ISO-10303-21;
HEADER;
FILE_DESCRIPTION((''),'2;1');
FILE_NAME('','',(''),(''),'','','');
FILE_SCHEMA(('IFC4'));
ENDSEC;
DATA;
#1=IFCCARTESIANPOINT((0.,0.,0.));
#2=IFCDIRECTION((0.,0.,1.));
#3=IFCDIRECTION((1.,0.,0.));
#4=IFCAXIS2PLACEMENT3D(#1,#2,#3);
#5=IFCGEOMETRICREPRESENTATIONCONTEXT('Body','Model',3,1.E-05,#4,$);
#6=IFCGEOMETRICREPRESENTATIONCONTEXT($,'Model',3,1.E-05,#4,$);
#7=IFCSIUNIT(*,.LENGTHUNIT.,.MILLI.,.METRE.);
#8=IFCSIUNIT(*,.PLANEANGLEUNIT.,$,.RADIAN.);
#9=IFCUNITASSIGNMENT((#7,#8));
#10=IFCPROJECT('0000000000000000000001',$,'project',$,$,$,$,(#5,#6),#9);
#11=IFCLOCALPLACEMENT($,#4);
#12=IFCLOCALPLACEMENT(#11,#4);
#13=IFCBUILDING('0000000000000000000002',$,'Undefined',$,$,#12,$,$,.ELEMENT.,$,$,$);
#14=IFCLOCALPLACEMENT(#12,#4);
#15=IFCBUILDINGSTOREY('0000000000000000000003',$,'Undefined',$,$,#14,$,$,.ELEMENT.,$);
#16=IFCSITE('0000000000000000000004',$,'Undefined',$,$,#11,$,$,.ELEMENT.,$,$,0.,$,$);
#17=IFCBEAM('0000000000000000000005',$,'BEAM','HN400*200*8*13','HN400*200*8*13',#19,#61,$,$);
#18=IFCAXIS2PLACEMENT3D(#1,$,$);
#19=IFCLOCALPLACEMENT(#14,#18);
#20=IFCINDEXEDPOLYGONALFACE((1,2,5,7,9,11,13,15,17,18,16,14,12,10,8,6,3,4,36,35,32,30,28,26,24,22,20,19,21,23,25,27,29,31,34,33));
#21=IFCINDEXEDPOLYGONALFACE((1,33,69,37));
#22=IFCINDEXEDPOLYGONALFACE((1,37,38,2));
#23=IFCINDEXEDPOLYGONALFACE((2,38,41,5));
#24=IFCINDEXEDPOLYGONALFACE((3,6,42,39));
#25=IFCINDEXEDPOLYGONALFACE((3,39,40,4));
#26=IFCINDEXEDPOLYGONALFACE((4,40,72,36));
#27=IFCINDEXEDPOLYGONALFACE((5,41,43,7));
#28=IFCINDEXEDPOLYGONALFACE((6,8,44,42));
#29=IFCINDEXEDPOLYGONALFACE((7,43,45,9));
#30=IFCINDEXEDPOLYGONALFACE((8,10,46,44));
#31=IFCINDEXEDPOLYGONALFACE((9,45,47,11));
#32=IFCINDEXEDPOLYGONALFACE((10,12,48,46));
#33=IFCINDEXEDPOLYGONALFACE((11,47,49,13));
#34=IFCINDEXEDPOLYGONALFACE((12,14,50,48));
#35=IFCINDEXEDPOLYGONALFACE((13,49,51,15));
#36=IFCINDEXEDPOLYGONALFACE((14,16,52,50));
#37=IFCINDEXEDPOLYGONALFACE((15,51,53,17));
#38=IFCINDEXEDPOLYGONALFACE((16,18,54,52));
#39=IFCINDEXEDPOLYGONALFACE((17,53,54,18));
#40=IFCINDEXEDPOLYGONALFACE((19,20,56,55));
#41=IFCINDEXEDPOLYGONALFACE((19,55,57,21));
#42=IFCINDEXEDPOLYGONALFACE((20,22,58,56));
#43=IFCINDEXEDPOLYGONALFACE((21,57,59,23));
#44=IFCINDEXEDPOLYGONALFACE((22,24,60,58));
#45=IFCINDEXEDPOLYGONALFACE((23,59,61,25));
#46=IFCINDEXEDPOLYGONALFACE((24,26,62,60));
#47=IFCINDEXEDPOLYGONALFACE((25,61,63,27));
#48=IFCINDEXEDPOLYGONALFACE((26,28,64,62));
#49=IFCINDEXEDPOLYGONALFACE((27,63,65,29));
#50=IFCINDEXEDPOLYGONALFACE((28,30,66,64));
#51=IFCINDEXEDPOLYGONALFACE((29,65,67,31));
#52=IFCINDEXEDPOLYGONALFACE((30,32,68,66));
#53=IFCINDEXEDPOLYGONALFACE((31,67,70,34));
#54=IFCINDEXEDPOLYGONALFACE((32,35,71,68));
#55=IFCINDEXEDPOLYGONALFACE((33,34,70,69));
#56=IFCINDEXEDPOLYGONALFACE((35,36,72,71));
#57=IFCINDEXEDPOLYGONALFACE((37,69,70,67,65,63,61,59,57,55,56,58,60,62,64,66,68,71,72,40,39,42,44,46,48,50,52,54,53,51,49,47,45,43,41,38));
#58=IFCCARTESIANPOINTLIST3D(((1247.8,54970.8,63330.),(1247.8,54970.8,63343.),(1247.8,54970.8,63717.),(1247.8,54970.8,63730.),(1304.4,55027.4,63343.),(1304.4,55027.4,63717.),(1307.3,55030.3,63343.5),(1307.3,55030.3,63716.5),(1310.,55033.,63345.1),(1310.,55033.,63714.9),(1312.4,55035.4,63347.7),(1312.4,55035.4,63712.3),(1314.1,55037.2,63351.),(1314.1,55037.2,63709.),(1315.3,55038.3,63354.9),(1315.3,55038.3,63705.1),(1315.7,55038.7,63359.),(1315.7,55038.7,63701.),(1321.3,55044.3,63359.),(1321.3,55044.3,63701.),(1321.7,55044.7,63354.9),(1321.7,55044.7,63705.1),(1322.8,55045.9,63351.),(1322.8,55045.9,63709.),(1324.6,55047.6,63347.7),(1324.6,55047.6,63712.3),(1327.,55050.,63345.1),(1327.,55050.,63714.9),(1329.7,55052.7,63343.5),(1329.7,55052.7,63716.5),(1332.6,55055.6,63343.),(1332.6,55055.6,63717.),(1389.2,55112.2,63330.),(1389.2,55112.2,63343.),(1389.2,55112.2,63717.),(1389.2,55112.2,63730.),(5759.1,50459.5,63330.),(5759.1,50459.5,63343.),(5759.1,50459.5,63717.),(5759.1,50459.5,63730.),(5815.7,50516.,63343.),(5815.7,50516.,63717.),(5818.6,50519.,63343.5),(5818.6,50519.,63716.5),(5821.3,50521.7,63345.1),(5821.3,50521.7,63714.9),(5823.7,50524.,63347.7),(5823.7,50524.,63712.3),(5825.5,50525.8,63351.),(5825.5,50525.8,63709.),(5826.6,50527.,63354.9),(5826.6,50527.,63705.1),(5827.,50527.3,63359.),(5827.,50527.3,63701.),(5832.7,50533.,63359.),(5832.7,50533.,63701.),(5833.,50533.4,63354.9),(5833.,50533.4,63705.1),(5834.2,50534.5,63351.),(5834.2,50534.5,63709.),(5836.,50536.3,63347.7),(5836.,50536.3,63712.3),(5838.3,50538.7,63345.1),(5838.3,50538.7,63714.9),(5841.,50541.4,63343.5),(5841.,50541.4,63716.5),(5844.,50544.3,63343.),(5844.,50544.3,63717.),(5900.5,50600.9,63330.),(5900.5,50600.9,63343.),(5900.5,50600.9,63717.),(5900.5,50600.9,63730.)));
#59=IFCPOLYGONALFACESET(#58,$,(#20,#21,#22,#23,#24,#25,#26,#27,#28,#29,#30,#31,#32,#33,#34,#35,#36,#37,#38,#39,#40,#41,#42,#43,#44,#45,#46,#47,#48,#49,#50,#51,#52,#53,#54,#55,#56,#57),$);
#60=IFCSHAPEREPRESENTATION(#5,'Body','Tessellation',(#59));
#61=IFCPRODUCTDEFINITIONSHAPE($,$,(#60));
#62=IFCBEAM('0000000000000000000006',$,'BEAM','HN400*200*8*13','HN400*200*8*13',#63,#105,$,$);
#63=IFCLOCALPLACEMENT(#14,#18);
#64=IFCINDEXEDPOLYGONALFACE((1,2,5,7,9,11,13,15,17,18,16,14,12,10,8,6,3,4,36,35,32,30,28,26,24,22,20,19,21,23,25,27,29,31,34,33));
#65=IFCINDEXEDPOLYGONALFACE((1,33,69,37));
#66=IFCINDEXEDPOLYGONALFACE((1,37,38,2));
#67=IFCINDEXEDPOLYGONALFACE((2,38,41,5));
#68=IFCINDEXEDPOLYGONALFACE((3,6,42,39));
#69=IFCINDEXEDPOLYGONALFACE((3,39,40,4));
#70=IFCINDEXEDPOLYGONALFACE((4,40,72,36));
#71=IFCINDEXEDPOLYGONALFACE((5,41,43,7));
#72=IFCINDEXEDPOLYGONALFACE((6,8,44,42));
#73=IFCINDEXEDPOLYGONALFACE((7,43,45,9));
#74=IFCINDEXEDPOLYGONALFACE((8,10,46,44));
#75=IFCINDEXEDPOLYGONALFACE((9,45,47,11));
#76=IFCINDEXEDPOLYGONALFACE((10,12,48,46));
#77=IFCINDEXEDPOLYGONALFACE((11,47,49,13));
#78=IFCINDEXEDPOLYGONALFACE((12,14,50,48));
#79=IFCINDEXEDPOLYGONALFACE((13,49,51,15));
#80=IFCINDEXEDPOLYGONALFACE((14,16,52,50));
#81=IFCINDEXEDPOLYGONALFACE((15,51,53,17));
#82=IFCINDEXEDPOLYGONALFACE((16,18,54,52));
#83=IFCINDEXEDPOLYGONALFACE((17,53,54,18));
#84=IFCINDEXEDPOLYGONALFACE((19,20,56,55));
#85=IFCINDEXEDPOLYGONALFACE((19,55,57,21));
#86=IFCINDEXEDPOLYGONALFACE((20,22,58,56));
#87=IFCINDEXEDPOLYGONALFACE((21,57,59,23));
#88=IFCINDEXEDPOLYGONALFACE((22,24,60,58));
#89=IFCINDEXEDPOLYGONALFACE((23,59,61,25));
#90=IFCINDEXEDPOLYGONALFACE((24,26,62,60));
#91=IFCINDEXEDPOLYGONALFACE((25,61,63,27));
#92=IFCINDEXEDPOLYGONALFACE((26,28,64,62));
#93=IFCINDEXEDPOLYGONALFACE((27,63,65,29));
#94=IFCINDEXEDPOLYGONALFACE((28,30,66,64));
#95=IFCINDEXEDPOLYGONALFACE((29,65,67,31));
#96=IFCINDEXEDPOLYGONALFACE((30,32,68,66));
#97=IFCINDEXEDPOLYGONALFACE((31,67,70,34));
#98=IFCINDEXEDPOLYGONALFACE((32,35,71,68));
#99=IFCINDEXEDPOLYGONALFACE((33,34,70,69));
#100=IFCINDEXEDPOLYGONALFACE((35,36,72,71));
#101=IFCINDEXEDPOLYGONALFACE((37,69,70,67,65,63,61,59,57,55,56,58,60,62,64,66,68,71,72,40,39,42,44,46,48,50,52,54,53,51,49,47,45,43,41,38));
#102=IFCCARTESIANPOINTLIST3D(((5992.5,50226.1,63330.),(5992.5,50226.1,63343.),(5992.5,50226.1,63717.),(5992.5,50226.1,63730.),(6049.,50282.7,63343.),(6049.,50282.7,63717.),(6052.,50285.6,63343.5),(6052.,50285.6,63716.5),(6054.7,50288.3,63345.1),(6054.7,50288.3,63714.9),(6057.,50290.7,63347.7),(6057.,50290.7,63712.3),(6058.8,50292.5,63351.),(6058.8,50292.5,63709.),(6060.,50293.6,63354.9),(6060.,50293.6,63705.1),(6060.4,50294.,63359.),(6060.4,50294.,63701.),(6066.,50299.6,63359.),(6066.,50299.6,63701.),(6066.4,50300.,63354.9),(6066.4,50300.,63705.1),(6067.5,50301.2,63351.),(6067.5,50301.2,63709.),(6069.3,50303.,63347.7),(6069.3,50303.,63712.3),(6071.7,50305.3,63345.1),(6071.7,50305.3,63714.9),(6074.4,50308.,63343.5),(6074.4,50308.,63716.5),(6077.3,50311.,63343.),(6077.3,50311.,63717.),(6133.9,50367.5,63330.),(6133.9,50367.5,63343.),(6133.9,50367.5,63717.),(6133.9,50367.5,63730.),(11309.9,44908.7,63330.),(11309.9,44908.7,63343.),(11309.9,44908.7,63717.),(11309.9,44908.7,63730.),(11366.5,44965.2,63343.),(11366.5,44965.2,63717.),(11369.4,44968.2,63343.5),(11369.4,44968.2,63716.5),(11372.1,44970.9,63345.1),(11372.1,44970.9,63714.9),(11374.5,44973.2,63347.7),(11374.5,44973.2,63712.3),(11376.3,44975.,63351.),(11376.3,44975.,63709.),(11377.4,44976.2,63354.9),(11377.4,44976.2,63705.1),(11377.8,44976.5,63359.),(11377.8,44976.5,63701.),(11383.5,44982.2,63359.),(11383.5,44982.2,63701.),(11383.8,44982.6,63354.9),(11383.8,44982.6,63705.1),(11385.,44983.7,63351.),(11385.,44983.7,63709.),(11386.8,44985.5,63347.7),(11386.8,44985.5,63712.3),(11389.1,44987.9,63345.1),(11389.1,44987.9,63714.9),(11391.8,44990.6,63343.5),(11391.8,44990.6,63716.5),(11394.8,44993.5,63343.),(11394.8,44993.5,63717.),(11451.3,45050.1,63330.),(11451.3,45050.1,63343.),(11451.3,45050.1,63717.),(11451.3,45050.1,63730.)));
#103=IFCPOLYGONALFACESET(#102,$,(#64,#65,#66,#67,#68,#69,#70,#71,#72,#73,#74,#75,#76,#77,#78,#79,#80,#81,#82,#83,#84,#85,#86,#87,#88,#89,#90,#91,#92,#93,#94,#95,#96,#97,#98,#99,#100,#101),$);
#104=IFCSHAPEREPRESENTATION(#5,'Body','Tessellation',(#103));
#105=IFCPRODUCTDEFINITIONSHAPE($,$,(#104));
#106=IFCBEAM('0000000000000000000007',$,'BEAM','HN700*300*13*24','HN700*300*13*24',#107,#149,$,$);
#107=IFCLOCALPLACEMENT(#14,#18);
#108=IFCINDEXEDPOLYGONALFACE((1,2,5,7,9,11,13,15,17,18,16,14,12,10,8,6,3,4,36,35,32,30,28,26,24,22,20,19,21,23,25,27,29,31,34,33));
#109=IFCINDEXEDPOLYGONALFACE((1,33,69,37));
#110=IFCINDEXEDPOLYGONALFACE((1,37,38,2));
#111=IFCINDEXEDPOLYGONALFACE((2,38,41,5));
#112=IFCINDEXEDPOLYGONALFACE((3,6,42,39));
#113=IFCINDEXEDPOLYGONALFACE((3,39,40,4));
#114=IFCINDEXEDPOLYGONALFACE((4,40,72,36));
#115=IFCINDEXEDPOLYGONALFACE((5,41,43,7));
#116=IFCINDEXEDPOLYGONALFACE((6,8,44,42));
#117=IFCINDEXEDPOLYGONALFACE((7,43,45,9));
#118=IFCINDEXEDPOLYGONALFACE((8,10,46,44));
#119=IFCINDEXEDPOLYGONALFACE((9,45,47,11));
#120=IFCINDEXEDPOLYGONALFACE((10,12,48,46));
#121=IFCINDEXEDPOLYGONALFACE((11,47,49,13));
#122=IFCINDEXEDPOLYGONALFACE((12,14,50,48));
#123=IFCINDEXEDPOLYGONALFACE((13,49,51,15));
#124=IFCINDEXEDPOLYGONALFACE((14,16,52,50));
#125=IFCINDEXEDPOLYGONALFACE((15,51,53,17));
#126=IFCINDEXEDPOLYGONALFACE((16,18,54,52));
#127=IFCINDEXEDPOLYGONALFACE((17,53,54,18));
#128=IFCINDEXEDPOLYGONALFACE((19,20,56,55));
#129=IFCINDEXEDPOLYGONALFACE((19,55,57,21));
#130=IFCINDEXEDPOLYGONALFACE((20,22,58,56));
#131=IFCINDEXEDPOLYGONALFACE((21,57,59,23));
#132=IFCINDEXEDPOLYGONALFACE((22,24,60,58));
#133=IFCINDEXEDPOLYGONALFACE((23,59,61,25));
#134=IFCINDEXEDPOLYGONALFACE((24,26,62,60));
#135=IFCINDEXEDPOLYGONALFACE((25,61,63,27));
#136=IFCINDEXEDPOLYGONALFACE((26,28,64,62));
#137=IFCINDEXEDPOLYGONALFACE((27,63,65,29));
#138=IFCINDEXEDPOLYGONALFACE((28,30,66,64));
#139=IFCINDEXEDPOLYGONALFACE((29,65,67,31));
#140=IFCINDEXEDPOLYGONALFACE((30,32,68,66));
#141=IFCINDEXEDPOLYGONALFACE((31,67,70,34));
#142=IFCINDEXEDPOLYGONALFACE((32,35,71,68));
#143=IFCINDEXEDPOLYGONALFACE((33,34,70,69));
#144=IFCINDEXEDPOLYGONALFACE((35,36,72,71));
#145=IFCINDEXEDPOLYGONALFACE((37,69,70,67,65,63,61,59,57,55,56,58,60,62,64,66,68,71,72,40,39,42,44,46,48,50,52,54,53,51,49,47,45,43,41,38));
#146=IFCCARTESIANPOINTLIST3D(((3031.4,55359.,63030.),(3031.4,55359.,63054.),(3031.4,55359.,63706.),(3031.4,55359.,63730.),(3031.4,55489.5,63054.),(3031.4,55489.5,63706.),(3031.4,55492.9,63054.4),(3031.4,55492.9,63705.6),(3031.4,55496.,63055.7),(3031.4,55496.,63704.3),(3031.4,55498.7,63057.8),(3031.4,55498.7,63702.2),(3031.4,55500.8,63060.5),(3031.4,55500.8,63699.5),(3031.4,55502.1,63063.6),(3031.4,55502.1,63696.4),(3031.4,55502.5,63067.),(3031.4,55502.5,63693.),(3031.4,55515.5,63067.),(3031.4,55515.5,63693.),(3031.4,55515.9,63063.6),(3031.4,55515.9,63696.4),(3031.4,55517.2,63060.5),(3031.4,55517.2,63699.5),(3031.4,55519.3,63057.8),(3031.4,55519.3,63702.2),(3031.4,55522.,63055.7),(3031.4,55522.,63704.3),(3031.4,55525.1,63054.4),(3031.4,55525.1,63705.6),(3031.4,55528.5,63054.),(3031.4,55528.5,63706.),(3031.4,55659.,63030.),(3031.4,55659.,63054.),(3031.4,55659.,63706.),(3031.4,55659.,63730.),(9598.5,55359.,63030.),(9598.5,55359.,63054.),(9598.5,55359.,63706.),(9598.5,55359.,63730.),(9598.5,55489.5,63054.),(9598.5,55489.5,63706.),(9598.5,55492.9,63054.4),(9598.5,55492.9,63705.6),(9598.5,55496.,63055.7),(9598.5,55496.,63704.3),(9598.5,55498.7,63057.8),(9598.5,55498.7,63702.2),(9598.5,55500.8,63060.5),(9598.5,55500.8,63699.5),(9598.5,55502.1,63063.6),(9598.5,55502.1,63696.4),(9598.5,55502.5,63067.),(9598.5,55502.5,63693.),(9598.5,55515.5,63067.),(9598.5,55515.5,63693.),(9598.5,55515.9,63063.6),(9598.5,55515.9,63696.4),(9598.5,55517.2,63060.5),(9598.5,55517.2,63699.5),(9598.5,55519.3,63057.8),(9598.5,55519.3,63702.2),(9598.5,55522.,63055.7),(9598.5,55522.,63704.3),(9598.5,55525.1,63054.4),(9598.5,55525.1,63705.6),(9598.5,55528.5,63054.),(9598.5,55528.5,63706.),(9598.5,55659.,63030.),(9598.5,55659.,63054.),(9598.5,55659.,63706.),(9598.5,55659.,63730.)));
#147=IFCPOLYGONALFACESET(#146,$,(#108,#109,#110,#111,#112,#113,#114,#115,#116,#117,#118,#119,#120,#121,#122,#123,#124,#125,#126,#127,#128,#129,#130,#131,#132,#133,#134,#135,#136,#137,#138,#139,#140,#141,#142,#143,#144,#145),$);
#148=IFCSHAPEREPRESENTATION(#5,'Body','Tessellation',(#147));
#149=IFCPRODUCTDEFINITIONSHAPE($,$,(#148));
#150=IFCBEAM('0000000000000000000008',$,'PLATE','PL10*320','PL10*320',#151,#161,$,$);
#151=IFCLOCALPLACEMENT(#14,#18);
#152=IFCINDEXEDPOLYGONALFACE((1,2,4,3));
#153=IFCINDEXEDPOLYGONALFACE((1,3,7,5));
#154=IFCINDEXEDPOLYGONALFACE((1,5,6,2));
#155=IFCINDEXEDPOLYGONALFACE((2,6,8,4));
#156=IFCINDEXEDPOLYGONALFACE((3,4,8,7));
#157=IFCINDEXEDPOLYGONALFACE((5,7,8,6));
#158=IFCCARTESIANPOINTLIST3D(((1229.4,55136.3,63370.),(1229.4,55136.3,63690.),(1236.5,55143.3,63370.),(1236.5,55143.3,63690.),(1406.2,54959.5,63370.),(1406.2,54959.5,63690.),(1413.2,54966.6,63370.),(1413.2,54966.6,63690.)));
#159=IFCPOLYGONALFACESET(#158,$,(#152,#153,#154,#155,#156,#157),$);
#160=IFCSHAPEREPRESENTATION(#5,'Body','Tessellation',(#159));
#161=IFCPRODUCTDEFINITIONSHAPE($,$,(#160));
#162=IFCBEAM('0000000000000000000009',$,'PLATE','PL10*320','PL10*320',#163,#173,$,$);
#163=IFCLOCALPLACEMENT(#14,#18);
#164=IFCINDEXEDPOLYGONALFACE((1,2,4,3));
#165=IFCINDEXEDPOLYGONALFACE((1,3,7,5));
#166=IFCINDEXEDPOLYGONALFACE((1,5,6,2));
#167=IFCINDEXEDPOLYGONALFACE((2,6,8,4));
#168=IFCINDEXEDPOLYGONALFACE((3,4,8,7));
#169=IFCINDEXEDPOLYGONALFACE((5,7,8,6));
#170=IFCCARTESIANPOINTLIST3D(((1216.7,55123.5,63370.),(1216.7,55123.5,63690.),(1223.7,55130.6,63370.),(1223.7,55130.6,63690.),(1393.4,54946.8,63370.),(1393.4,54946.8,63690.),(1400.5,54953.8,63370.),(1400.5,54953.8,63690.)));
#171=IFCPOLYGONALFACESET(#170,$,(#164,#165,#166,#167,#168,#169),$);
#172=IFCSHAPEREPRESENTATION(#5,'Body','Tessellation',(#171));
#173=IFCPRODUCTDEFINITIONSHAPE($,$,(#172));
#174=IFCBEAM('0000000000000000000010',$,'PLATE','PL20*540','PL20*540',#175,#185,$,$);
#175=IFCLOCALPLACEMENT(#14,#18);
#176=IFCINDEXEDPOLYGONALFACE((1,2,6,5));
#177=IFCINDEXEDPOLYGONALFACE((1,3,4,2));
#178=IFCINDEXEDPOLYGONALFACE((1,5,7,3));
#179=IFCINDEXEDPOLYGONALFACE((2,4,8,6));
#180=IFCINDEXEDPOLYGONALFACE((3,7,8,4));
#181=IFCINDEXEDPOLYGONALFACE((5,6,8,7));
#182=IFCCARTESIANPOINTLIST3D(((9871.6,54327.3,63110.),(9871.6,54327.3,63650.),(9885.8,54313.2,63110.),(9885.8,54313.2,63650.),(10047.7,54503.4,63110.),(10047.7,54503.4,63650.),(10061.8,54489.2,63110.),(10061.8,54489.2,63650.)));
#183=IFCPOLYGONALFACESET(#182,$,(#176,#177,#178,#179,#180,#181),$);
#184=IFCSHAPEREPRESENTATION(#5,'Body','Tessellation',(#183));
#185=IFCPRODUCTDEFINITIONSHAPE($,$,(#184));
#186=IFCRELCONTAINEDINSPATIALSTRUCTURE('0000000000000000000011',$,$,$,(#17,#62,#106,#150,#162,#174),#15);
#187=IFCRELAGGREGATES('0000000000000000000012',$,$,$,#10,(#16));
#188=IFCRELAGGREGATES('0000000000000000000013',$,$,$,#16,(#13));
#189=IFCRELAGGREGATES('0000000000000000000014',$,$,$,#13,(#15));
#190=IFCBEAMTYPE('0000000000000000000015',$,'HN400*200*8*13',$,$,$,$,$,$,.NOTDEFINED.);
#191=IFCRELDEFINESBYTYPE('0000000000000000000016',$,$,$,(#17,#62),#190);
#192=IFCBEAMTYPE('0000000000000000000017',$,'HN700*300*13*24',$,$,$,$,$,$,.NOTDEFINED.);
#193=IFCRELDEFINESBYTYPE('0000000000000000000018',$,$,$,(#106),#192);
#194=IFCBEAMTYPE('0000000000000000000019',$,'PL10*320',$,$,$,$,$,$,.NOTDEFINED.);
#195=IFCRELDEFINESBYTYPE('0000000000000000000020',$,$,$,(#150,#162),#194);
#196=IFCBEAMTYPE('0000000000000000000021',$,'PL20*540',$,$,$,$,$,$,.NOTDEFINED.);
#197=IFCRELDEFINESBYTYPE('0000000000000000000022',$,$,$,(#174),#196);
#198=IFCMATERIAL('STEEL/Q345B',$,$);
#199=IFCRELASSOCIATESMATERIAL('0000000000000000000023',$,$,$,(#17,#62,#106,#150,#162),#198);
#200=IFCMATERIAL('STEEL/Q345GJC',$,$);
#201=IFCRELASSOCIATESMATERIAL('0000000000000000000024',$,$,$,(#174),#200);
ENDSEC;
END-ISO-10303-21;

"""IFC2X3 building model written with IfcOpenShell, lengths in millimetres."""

from ifc_helpers import new_model, si_unit, frame, origin_with_axes, origin_2d_with_axis, place, context, project, spatial, rectangle, i_section, extrude, material, type_object, element, save


model = new_model("IFC2X3")

# Units and contexts
model_context_1 = context("Model", 3, precision=1e-05, world=origin_with_axes(), identifier="Body")
model_context_2 = context("Model", 3, precision=1e-05, world=origin_with_axes())
ifc_project = project(units=[si_unit("LENGTHUNIT", "METRE", prefix="MILLI"), si_unit("PLANEANGLEUNIT", "RADIAN")], contexts=[model_context_1, model_context_2])

# Site, building, storey
site_placement = place(None, origin_with_axes())
site = spatial("IfcSite", under=ifc_project, at=site_placement, Name="Undefined", CompositionType="ELEMENT", RefElevation=0.0)
building_placement = place(site_placement, origin_with_axes())
building = spatial("IfcBuilding", under=site, at=building_placement, Name="Undefined", CompositionType="ELEMENT")
storey_placement = place(building_placement, origin_with_axes())
storey = spatial("IfcBuildingStorey", under=building, at=storey_placement, Name="Undefined", CompositionType="ELEMENT")

# Beams
ifc_material_1 = material(Name="STEEL/Q345B")
beam_type_1 = type_object("IfcBeamType", Name="HN400*200*8*13", PredefinedType="NOTDEFINED")
beam_1_placement = place(storey_placement, frame((1311.4, 55048.6, 63530.0), z_axis=(0.0, 0.0, 1.0), x_axis=(0.707107, -0.707107, 0.0)))
element("IfcBeam", 1, at=beam_1_placement, inside=storey, type_object=beam_type_1, material=ifc_material_1, Name="BEAM", Description="HN400*200*8*13", ObjectType="HN400*200*8*13", context=model_context_1, shape_type="SweptSolid", body=[
    extrude(i_section(OverallWidth=200.0, OverallDepth=400.0, WebThickness=8.0, FlangeThickness=13.0, FilletRadius=16.0, at=origin_2d_with_axis()), frame((6390.0, 0.0, 0.0), z_axis=(-1.0, 0.0, 0.0), x_axis=(0.0, -1.0, 0.0)), (0.0, 0.0, 1.0), 6380.0),
])
beam_2_placement = place(storey_placement, frame((5792.5, 50567.5, 63530.0), z_axis=(0.0, 0.0, 1.0), x_axis=(0.707107, -0.707107, 0.0)))
element("IfcBeam", 2, at=beam_2_placement, inside=storey, type_object=beam_type_1, material=ifc_material_1, Name="BEAM", Description="HN400*200*8*13", ObjectType="HN400*200*8*13", context=model_context_1, shape_type="SweptSolid", body=[
    extrude(i_section(OverallWidth=200.0, OverallDepth=400.0, WebThickness=8.0, FlangeThickness=13.0, FilletRadius=16.0, at=origin_2d_with_axis()), frame((7902.8, 0.0, 0.0), z_axis=(-1.0, 0.0, 0.0), x_axis=(0.0, -1.0, 0.0)), (0.0, 0.0, 1.0), 7520.0),
])
beam_type_2 = type_object("IfcBeamType", Name="HN700*300*13*24", PredefinedType="NOTDEFINED")
beam_3_placement = place(storey_placement, frame((9598.5, 55509.0, 63380.0), z_axis=(0.0, 0.0, 1.0), x_axis=(-1.0, 0.0, 0.0)))
element("IfcBeam", 3, at=beam_3_placement, inside=storey, type_object=beam_type_2, material=ifc_material_1, Name="BEAM", Description="HN700*300*13*24", ObjectType="HN700*300*13*24", context=model_context_1, shape_type="SweptSolid", body=[
    extrude(i_section(OverallWidth=300.0, OverallDepth=700.0, WebThickness=13.0, FlangeThickness=24.0, FilletRadius=13.0, at=origin_2d_with_axis()), frame((6567.1, 0.0, 0.0), z_axis=(-1.0, 0.0, 0.0), x_axis=(0.0, -1.0, 0.0)), (0.0, 0.0, 1.0), 6567.1),
])
beam_type_3 = type_object("IfcBeamType", Name="PL10*320", PredefinedType="NOTDEFINED")
for number, where, z_axis, x_axis, name in (
    (4, (1232.9, 55139.8, 63530.0), (0.0, 0.0, 1.0), (0.707107, -0.707107, 0.0), "PLATE"),
    (5, (1220.2, 55127.1, 63530.0), (0.0, 0.0, 1.0), (0.707107, -0.707107, 0.0), "PLATE"),
):
    element("IfcBeam", number, at=place(storey_placement, frame(where, z_axis=z_axis, x_axis=x_axis)), inside=storey, type_object=beam_type_3, material=ifc_material_1, Name=name, Description="PL10*320", ObjectType="PL10*320", context=model_context_1, shape_type="SweptSolid", body=[
        extrude(rectangle(XDim=10.0, YDim=320.0, at=origin_2d_with_axis()), frame((250.0, 0.0, 0.0), z_axis=(-1.0, 0.0, 0.0), x_axis=(0.0, -1.0, 0.0)), (0.0, 0.0, 1.0), 250.0),
    ])
ifc_material_2 = material(Name="STEEL/Q345GJC")
beam_type_4 = type_object("IfcBeamType", Name="PL20*540", PredefinedType="NOTDEFINED")
beam_4_placement = place(storey_placement, frame((10054.8, 54496.3, 63380.0), z_axis=(0.0, 0.0, 1.0), x_axis=(-0.707107, -0.707107, 0.0)))
element("IfcBeam", 6, at=beam_4_placement, inside=storey, type_object=beam_type_4, material=ifc_material_2, Name="PLATE", Description="PL20*540", ObjectType="PL20*540", context=model_context_1, shape_type="SweptSolid", body=[
    extrude(rectangle(XDim=20.0, YDim=540.0, at=origin_2d_with_axis()), frame((249.0, 0.0, 0.0), z_axis=(-1.0, 0.0, 0.0), x_axis=(0.0, -1.0, 0.0)), (0.0, 0.0, 1.0), 249.0),
])

save(model, "model.ifc")
